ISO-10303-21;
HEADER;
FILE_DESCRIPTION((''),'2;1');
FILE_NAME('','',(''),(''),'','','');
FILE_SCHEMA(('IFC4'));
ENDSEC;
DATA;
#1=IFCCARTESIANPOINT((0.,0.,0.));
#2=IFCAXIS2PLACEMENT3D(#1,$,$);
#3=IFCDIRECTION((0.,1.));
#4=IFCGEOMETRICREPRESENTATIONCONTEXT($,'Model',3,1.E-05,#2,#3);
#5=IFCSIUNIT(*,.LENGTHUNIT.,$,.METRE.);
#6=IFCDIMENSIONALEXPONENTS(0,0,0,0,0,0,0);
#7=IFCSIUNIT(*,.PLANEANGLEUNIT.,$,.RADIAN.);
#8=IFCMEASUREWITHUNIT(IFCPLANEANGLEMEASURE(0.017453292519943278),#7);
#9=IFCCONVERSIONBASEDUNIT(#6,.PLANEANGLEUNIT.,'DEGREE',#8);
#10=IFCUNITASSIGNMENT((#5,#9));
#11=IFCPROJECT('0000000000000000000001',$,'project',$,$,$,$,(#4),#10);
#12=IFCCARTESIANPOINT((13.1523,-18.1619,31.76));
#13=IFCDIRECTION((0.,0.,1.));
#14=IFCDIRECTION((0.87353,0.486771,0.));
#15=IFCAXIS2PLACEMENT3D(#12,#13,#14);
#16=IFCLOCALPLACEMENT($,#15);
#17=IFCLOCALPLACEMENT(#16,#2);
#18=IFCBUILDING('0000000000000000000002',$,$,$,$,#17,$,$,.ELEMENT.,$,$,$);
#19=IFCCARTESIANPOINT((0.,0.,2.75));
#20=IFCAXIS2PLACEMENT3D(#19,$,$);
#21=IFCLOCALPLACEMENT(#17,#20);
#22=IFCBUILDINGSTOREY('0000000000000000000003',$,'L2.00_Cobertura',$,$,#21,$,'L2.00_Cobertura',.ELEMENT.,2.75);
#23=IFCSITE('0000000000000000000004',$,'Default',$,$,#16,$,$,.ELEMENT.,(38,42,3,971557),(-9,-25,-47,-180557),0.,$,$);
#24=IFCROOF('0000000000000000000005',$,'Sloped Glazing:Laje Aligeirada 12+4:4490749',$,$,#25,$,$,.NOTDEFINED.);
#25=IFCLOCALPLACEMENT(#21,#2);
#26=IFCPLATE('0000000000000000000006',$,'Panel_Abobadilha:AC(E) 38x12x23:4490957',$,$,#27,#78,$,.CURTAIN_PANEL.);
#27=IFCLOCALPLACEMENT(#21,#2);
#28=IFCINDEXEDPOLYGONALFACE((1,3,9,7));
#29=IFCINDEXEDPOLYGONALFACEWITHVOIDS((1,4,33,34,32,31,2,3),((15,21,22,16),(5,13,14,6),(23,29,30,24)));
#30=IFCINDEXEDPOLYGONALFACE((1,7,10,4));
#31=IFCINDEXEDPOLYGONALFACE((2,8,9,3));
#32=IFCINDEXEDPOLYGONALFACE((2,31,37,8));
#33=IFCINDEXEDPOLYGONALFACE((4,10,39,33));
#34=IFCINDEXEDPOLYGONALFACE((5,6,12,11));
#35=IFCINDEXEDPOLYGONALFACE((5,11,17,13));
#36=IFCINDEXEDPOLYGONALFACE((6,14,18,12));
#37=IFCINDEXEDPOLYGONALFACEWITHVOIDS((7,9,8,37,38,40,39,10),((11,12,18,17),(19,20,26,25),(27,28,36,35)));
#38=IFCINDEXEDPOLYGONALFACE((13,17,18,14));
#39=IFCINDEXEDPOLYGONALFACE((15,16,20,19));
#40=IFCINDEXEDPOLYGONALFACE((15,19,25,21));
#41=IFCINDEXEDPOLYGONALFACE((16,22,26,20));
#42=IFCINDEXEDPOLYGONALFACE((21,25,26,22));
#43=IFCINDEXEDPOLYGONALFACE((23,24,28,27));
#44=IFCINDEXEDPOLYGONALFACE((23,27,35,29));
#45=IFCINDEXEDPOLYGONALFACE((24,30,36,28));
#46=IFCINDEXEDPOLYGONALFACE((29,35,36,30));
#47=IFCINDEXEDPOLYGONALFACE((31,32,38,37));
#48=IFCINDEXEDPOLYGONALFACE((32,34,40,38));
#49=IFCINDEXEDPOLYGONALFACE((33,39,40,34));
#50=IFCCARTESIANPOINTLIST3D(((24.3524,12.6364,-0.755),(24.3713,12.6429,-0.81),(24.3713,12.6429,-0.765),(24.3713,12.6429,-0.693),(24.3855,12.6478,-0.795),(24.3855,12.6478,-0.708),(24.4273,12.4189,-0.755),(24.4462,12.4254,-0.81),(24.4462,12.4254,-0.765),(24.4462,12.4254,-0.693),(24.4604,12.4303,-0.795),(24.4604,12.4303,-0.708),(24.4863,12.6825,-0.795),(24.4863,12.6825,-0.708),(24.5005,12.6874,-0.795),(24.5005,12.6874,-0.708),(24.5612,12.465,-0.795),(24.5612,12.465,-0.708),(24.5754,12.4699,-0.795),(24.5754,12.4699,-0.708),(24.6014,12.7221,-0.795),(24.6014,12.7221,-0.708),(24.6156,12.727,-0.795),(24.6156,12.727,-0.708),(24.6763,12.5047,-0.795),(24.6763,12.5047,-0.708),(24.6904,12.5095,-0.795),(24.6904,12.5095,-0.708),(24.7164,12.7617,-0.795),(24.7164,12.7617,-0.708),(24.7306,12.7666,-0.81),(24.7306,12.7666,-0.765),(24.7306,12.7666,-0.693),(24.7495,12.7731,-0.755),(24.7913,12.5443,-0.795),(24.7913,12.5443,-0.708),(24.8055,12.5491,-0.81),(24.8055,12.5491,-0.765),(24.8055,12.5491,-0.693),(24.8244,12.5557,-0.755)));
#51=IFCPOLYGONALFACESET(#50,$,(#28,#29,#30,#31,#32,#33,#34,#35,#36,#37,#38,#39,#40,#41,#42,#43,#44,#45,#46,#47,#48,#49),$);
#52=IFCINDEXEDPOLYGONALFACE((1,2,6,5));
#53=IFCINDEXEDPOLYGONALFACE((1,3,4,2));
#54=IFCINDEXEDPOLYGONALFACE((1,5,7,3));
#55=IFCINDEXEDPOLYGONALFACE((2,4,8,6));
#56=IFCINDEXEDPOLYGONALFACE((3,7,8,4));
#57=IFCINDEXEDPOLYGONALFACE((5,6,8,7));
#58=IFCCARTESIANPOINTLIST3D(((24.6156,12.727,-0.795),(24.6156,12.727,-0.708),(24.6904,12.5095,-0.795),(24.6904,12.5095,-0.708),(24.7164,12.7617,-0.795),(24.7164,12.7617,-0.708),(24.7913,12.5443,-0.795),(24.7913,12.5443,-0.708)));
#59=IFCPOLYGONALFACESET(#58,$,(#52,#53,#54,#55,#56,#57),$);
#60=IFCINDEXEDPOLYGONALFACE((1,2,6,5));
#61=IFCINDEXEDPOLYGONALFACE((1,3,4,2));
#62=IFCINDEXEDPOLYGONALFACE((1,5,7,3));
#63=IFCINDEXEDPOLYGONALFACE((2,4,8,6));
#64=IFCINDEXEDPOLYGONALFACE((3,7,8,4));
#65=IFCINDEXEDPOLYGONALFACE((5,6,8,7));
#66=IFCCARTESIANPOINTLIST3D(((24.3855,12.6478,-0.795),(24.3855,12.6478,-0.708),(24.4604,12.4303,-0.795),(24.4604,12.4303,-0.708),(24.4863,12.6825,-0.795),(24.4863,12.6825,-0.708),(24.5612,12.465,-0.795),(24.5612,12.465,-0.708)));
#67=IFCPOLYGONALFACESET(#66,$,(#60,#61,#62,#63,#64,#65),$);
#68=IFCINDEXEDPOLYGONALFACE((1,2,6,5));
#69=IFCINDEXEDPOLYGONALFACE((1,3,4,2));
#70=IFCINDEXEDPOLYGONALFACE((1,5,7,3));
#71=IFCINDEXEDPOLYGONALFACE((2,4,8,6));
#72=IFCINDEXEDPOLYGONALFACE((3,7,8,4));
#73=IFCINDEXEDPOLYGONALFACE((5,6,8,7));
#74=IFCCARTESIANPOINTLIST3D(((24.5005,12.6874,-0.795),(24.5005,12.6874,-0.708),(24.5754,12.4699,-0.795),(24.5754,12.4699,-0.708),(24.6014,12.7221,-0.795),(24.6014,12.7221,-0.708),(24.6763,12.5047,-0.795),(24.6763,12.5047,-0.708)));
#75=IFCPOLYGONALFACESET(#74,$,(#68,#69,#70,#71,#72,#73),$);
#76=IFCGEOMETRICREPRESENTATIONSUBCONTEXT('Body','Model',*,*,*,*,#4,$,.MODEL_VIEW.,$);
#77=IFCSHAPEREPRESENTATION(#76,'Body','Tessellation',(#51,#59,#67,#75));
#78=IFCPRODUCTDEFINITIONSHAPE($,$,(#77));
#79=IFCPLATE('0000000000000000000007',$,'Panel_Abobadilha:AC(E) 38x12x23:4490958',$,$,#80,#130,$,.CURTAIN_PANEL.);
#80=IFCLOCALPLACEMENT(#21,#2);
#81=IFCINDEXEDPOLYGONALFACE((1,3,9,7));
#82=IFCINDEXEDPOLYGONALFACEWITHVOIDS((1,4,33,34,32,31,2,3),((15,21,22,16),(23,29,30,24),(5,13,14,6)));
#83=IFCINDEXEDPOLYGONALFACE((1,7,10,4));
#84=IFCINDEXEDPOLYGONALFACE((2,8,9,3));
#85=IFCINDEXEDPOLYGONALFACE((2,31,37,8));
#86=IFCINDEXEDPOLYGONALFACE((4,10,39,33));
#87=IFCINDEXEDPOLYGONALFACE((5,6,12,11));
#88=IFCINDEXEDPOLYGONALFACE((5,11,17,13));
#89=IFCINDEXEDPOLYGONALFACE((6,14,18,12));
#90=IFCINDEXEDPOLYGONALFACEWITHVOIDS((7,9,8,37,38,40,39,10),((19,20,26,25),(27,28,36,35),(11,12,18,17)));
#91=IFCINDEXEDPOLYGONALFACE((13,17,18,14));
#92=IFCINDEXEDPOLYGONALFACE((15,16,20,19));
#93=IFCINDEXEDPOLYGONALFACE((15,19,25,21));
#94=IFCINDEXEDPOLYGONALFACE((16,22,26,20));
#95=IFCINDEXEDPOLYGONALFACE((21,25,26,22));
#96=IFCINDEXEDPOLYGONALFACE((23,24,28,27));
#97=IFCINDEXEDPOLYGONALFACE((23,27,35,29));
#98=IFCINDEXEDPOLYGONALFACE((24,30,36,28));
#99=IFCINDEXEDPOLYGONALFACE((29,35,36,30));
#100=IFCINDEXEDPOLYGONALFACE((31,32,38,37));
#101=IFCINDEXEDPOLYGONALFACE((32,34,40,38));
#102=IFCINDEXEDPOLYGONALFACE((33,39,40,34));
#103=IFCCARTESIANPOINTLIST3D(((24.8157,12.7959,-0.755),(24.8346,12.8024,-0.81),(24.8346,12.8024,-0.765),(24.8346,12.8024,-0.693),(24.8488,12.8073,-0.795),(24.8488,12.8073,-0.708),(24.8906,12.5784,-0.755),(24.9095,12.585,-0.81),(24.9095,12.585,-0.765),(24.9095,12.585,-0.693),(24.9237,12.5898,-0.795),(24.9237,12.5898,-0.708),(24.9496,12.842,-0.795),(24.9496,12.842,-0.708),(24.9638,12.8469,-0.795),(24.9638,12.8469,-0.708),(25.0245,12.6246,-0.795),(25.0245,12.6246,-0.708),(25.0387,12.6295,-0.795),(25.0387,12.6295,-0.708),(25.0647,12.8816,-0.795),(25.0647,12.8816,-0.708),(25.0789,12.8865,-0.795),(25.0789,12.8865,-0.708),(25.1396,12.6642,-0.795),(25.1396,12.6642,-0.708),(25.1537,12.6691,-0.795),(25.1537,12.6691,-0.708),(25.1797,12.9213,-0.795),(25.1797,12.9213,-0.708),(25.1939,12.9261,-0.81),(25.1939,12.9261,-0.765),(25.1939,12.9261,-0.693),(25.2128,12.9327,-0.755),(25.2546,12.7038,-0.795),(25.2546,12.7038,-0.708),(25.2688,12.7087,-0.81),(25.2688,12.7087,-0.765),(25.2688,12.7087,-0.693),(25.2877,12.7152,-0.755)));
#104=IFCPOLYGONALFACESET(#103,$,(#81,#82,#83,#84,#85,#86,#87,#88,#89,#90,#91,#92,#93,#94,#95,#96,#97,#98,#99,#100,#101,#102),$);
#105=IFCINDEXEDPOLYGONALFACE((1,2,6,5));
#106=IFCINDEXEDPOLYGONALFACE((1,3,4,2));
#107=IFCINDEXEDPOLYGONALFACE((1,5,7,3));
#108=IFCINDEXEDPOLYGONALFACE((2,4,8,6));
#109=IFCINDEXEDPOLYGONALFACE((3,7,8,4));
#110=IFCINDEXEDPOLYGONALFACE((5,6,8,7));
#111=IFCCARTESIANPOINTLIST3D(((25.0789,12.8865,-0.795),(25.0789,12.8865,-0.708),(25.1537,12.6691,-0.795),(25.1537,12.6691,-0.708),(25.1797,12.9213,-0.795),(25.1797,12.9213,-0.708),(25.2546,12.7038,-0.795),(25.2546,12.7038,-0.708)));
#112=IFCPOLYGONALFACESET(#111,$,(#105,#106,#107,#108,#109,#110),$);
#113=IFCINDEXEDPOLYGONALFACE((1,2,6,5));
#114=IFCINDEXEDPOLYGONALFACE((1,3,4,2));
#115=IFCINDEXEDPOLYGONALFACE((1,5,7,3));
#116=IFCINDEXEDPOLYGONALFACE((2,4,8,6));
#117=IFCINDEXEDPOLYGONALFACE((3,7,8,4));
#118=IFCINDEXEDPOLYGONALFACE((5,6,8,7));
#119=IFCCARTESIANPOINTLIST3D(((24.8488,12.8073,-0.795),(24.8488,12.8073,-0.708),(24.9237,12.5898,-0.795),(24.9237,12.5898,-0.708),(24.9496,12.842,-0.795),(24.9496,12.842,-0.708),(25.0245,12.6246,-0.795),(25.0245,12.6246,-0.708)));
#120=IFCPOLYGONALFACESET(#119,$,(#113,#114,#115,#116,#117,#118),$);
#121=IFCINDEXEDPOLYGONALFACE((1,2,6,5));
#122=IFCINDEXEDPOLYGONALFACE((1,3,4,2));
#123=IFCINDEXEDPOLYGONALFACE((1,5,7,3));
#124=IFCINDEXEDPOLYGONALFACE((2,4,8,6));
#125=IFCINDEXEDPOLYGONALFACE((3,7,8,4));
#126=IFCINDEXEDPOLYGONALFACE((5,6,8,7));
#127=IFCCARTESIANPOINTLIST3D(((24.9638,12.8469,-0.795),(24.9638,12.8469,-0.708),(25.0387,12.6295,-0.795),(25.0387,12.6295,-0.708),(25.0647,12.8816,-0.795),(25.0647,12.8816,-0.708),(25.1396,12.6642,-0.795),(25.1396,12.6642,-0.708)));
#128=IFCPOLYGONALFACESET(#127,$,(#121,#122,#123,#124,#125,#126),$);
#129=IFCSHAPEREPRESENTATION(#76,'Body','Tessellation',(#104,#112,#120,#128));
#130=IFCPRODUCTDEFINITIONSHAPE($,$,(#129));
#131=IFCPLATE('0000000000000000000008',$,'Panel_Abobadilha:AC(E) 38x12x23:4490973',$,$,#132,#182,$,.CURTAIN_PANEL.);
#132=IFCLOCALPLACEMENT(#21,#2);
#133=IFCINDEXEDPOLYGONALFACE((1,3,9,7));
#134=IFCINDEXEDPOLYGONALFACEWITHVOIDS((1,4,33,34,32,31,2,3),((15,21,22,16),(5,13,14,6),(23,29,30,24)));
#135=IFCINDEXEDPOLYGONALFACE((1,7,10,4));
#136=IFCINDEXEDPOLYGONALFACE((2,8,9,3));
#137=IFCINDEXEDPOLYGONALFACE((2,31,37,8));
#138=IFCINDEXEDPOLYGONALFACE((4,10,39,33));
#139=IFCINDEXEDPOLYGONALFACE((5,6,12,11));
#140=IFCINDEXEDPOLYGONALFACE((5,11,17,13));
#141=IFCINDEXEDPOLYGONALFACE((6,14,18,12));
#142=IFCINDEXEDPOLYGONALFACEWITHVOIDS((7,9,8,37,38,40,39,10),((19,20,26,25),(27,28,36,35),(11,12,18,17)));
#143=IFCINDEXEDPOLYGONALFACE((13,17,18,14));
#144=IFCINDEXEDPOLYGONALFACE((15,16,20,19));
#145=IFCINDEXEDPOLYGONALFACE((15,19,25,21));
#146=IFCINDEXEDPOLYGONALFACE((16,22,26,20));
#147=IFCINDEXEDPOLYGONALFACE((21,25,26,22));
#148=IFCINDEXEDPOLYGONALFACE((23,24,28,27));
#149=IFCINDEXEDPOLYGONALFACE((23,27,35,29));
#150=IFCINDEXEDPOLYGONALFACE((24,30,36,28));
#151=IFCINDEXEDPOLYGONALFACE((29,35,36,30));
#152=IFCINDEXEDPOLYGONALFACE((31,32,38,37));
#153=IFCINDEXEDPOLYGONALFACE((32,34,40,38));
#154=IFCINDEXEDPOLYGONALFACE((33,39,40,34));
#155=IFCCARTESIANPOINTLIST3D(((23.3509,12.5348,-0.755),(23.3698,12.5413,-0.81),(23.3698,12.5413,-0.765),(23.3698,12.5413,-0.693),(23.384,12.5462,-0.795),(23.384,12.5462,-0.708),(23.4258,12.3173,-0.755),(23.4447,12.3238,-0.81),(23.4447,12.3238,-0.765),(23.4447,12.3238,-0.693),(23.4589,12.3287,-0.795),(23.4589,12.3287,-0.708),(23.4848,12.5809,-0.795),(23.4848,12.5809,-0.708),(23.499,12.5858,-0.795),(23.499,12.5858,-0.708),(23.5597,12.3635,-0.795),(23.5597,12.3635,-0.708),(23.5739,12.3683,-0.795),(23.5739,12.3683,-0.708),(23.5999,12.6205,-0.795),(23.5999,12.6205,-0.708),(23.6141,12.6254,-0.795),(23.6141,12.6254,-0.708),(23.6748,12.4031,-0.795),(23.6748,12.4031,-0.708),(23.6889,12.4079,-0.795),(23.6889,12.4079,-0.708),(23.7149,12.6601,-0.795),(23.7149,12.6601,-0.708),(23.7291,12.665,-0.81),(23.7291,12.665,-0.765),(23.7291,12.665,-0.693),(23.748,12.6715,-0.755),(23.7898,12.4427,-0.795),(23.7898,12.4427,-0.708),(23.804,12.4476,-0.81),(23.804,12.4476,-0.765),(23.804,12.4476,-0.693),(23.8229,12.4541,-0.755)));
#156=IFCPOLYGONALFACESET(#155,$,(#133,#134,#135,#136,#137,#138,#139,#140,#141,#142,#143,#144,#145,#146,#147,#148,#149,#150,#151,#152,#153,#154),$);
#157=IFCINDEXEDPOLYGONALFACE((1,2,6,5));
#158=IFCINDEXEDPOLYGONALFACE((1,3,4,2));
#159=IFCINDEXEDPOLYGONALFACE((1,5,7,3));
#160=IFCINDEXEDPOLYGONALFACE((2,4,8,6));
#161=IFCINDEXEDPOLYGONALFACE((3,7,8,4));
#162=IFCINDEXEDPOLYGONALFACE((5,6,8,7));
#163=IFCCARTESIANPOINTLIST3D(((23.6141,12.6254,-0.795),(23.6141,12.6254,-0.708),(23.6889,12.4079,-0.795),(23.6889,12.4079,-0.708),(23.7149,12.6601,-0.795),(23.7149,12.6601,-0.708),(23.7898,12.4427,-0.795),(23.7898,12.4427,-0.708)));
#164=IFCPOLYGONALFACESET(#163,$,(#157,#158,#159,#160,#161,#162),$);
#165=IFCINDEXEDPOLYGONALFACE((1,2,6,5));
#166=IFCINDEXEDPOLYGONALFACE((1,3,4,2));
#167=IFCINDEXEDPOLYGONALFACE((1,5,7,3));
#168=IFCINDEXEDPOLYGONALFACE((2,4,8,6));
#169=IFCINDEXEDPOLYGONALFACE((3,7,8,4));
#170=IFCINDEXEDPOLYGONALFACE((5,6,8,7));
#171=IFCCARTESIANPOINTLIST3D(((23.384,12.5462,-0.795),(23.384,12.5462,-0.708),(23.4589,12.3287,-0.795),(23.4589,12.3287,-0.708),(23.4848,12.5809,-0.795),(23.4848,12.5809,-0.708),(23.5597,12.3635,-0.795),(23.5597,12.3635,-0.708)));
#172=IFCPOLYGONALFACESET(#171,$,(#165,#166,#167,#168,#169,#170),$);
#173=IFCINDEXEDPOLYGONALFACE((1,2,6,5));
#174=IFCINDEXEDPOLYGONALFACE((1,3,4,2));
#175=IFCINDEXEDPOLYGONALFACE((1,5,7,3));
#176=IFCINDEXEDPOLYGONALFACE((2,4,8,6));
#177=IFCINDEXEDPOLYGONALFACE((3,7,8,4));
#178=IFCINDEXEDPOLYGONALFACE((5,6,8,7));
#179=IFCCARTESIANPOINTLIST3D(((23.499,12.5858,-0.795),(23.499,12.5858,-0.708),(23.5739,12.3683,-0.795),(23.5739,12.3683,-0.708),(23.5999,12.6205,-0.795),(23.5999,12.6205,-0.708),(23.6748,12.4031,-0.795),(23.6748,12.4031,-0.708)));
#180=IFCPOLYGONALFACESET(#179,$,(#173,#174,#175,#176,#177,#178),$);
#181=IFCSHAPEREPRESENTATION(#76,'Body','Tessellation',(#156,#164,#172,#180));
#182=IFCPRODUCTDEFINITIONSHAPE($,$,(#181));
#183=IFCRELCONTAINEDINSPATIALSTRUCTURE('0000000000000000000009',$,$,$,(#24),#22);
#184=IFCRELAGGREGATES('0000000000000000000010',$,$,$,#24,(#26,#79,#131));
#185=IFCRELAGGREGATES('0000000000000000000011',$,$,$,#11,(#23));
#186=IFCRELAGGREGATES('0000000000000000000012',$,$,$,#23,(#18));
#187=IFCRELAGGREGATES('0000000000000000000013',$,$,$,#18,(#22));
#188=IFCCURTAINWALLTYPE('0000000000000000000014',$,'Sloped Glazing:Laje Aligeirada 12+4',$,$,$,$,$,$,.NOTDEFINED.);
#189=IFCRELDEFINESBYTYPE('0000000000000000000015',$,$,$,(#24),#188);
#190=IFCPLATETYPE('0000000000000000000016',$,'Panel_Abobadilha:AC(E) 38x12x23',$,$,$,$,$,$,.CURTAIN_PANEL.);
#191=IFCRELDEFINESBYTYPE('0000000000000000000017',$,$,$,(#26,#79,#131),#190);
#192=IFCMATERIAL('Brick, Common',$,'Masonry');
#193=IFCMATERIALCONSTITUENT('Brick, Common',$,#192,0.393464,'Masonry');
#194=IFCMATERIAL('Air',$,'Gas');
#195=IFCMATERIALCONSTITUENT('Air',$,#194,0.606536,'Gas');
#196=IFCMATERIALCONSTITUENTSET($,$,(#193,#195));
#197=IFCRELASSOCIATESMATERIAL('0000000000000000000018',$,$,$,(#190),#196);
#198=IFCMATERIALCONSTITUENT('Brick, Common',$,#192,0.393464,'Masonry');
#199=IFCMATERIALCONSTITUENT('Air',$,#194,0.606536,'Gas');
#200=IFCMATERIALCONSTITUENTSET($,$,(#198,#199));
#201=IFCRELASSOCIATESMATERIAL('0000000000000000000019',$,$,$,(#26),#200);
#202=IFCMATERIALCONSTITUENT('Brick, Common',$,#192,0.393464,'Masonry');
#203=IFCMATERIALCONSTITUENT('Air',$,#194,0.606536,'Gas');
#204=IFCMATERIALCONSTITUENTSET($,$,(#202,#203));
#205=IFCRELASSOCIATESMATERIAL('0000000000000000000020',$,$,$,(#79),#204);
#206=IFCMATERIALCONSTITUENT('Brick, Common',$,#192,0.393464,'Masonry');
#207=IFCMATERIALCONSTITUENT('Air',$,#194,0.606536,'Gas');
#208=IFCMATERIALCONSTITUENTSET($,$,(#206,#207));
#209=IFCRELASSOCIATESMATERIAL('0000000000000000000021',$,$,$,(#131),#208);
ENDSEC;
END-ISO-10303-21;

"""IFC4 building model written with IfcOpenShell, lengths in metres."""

from ifc_helpers import new_model, entity, si_unit, converted_unit, direction, frame, origin, place, context, subcontext, project, spatial, indexed_curve, outline, extrude, source, transform, mapped, material, constituent, constituent_set, type_object, type_shapes, element, aggregate, save


model = new_model("IFC4")

# Units and contexts
model_context = context("Model", 3, precision=1e-05, world=origin(), true_north=direction((0.0, 1.0)))
body_context = subcontext(model_context, "Body", "Model", "MODEL_VIEW")
ifc_project = project(units=[si_unit("LENGTHUNIT", "METRE"), converted_unit("PLANEANGLEUNIT", "DEGREE", entity("IfcPlaneAngleMeasure", 0.017453292519943278), si_unit("PLANEANGLEUNIT", "RADIAN"), dimensions=[0, 0, 0, 0, 0, 0, 0])], contexts=[model_context])

# Site, building, storey
site_placement = place(None, frame((13.1523, -18.1619, 31.76), z_axis=(0.0, 0.0, 1.0), x_axis=(0.87353, 0.486771, 0.0)))
site = spatial("IfcSite", under=ifc_project, at=site_placement, Name="Default", CompositionType="ELEMENT", RefLatitude=(38, 42, 3, 971557), RefLongitude=(-9, -25, -47, -180557), RefElevation=0.0)
building_placement = place(site_placement, origin())
building = spatial("IfcBuilding", under=site, at=building_placement, CompositionType="ELEMENT")
storey_placement = place(building_placement, frame((0.0, 0.0, 2.75)))
storey = spatial("IfcBuildingStorey", under=building, at=storey_placement, Name="L2.00_Cobertura", LongName="L2.00_Cobertura", CompositionType="ELEMENT", Elevation=2.75)

# Roof, plates
curtain_wall_type = type_object("IfcCurtainWallType", Name="Sloped Glazing:Laje Aligeirada 12+4", PredefinedType="NOTDEFINED")
roof_placement = place(storey_placement, frame((0.0, 0.0, -2.75)))
roof = element("IfcRoof", 1, at=roof_placement, inside=storey, type_object=curtain_wall_type, Name="Sloped Glazing:Laje Aligeirada 12+4:4490749", PredefinedType="NOTDEFINED")
ifc_material_1 = material(Name="Brick, Common", Category="Masonry")
ifc_material_2 = material(Name="Air", Category="Gas")
ifc_constituent_1 = constituent(ifc_material_1, Name="Brick, Common", Category="Masonry", fraction=0.393464)
ifc_constituent_2 = constituent(ifc_material_2, Name="Air", Category="Gas", fraction=0.606536)
ifc_constituent_set_1 = constituent_set(constituents=[ifc_constituent_1, ifc_constituent_2])
plate_type = type_object("IfcPlateType", Name="Panel_Abobadilha:AC(E) 38x12x23", PredefinedType="CURTAIN_PANEL", material=ifc_constituent_set_1)
shared_shape_1 = source(origin(), body_context, "Body", "SweptSolid", [
    extrude(outline(indexed_curve([(-0.19, -0.0543), (0.19, -0.0543), (0.19, -0.0093), (0.21, 0.0007), (0.19, 0.0628), (-0.19, 0.0628), (-0.21, 0.0007), (-0.19, -0.0093), (-0.19, -0.0543)], self_intersect=False), holes=[indexed_curve([(-0.0683, 0.0477), (-0.0683, -0.0393), (-0.175, -0.0393), (-0.175, 0.0477), (-0.0683, 0.0477)], self_intersect=False), indexed_curve([(0.0533, 0.0477), (0.0533, -0.0393), (-0.0533, -0.0393), (-0.0533, 0.0477), (0.0533, 0.0477)], self_intersect=False), indexed_curve([(0.175, 0.0477), (0.175, -0.0393), (0.0683, -0.0393), (0.0683, 0.0477), (0.175, 0.0477)], self_intersect=False)]), frame((0.0, 0.0543, 0.0)), (0.0, 0.0, 1.0), 0.23),
    extrude(outline(indexed_curve([(-0.0533, -0.0435), (0.0533, -0.0435), (0.0533, 0.0435), (-0.0533, 0.0435), (-0.0533, -0.0435)], self_intersect=False)), frame((0.1217, 0.0585, 0.0), z_axis=(0.0, 0.0, 1.0), x_axis=(-1.0, 0.0, 0.0)), (0.0, 0.0, 1.0), 0.23),
    extrude(outline(indexed_curve([(-0.0533, -0.0435), (0.0533, -0.0435), (0.0533, 0.0435), (-0.0533, 0.0435), (-0.0533, -0.0435)], self_intersect=False)), frame((-0.1217, 0.0585, 0.0), z_axis=(0.0, 0.0, 1.0), x_axis=(-1.0, 0.0, 0.0)), (0.0, 0.0, 1.0), 0.23),
    extrude(outline(indexed_curve([(-0.0533, -0.0435), (0.0533, -0.0435), (0.0533, 0.0435), (-0.0533, 0.0435), (-0.0533, -0.0435)], self_intersect=False)), frame((0.0, 0.0585, 0.0), z_axis=(0.0, 0.0, 1.0), x_axis=(-1.0, 0.0, 0.0)), (0.0, 0.0, 1.0), 0.23),
])
type_shapes(plate_type, [shared_shape_1])
ifc_constituent_3 = constituent(ifc_material_1, Name="Brick, Common", Category="Masonry", fraction=0.393464)
ifc_constituent_4 = constituent(ifc_material_2, Name="Air", Category="Gas", fraction=0.606536)
ifc_constituent_set_2 = constituent_set(constituents=[ifc_constituent_3, ifc_constituent_4])
plate_1_placement = place(roof_placement, frame((24.5509, 12.7048, 1.94), z_axis=(0.325568, -0.945519, 0.0), x_axis=(0.945519, 0.325568, 0.0)))
plate_1 = element("IfcPlate", 2, at=plate_1_placement, type_object=plate_type, material=ifc_constituent_set_2, Name="Panel_Abobadilha:AC(E) 38x12x23:4490957", PredefinedType="CURTAIN_PANEL", context=body_context, shape_type="MappedRepresentation", body=[
    mapped(shared_shape_1, transform((0.0, 0.0, 0.0), scale=1.0)),
])
ifc_constituent_5 = constituent(ifc_material_1, Name="Brick, Common", Category="Masonry", fraction=0.393464)
ifc_constituent_6 = constituent(ifc_material_2, Name="Air", Category="Gas", fraction=0.606536)
ifc_constituent_set_3 = constituent_set(constituents=[ifc_constituent_5, ifc_constituent_6])
plate_2_placement = place(roof_placement, frame((25.0142, 12.8643, 1.94), z_axis=(0.325568, -0.945519, 0.0), x_axis=(0.945519, 0.325568, 0.0)))
plate_2 = element("IfcPlate", 3, at=plate_2_placement, type_object=plate_type, material=ifc_constituent_set_3, Name="Panel_Abobadilha:AC(E) 38x12x23:4490958", PredefinedType="CURTAIN_PANEL", context=body_context, shape_type="MappedRepresentation", body=[
    mapped(shared_shape_1, transform((0.0, 0.0, 0.0), scale=1.0)),
])
ifc_constituent_7 = constituent(ifc_material_1, Name="Brick, Common", Category="Masonry", fraction=0.393464)
ifc_constituent_8 = constituent(ifc_material_2, Name="Air", Category="Gas", fraction=0.606536)
ifc_constituent_set_4 = constituent_set(constituents=[ifc_constituent_7, ifc_constituent_8])
plate_3_placement = place(roof_placement, frame((23.5495, 12.6032, 1.94), z_axis=(0.325568, -0.945519, 0.0), x_axis=(0.945519, 0.325568, 0.0)))
plate_3 = element("IfcPlate", 4, at=plate_3_placement, type_object=plate_type, material=ifc_constituent_set_4, Name="Panel_Abobadilha:AC(E) 38x12x23:4490973", PredefinedType="CURTAIN_PANEL", context=body_context, shape_type="MappedRepresentation", body=[
    mapped(shared_shape_1, transform((0.0, 0.0, 0.0), scale=1.0)),
])
aggregate(roof, [plate_1, plate_2, plate_3])

save(model, "model.ifc")
